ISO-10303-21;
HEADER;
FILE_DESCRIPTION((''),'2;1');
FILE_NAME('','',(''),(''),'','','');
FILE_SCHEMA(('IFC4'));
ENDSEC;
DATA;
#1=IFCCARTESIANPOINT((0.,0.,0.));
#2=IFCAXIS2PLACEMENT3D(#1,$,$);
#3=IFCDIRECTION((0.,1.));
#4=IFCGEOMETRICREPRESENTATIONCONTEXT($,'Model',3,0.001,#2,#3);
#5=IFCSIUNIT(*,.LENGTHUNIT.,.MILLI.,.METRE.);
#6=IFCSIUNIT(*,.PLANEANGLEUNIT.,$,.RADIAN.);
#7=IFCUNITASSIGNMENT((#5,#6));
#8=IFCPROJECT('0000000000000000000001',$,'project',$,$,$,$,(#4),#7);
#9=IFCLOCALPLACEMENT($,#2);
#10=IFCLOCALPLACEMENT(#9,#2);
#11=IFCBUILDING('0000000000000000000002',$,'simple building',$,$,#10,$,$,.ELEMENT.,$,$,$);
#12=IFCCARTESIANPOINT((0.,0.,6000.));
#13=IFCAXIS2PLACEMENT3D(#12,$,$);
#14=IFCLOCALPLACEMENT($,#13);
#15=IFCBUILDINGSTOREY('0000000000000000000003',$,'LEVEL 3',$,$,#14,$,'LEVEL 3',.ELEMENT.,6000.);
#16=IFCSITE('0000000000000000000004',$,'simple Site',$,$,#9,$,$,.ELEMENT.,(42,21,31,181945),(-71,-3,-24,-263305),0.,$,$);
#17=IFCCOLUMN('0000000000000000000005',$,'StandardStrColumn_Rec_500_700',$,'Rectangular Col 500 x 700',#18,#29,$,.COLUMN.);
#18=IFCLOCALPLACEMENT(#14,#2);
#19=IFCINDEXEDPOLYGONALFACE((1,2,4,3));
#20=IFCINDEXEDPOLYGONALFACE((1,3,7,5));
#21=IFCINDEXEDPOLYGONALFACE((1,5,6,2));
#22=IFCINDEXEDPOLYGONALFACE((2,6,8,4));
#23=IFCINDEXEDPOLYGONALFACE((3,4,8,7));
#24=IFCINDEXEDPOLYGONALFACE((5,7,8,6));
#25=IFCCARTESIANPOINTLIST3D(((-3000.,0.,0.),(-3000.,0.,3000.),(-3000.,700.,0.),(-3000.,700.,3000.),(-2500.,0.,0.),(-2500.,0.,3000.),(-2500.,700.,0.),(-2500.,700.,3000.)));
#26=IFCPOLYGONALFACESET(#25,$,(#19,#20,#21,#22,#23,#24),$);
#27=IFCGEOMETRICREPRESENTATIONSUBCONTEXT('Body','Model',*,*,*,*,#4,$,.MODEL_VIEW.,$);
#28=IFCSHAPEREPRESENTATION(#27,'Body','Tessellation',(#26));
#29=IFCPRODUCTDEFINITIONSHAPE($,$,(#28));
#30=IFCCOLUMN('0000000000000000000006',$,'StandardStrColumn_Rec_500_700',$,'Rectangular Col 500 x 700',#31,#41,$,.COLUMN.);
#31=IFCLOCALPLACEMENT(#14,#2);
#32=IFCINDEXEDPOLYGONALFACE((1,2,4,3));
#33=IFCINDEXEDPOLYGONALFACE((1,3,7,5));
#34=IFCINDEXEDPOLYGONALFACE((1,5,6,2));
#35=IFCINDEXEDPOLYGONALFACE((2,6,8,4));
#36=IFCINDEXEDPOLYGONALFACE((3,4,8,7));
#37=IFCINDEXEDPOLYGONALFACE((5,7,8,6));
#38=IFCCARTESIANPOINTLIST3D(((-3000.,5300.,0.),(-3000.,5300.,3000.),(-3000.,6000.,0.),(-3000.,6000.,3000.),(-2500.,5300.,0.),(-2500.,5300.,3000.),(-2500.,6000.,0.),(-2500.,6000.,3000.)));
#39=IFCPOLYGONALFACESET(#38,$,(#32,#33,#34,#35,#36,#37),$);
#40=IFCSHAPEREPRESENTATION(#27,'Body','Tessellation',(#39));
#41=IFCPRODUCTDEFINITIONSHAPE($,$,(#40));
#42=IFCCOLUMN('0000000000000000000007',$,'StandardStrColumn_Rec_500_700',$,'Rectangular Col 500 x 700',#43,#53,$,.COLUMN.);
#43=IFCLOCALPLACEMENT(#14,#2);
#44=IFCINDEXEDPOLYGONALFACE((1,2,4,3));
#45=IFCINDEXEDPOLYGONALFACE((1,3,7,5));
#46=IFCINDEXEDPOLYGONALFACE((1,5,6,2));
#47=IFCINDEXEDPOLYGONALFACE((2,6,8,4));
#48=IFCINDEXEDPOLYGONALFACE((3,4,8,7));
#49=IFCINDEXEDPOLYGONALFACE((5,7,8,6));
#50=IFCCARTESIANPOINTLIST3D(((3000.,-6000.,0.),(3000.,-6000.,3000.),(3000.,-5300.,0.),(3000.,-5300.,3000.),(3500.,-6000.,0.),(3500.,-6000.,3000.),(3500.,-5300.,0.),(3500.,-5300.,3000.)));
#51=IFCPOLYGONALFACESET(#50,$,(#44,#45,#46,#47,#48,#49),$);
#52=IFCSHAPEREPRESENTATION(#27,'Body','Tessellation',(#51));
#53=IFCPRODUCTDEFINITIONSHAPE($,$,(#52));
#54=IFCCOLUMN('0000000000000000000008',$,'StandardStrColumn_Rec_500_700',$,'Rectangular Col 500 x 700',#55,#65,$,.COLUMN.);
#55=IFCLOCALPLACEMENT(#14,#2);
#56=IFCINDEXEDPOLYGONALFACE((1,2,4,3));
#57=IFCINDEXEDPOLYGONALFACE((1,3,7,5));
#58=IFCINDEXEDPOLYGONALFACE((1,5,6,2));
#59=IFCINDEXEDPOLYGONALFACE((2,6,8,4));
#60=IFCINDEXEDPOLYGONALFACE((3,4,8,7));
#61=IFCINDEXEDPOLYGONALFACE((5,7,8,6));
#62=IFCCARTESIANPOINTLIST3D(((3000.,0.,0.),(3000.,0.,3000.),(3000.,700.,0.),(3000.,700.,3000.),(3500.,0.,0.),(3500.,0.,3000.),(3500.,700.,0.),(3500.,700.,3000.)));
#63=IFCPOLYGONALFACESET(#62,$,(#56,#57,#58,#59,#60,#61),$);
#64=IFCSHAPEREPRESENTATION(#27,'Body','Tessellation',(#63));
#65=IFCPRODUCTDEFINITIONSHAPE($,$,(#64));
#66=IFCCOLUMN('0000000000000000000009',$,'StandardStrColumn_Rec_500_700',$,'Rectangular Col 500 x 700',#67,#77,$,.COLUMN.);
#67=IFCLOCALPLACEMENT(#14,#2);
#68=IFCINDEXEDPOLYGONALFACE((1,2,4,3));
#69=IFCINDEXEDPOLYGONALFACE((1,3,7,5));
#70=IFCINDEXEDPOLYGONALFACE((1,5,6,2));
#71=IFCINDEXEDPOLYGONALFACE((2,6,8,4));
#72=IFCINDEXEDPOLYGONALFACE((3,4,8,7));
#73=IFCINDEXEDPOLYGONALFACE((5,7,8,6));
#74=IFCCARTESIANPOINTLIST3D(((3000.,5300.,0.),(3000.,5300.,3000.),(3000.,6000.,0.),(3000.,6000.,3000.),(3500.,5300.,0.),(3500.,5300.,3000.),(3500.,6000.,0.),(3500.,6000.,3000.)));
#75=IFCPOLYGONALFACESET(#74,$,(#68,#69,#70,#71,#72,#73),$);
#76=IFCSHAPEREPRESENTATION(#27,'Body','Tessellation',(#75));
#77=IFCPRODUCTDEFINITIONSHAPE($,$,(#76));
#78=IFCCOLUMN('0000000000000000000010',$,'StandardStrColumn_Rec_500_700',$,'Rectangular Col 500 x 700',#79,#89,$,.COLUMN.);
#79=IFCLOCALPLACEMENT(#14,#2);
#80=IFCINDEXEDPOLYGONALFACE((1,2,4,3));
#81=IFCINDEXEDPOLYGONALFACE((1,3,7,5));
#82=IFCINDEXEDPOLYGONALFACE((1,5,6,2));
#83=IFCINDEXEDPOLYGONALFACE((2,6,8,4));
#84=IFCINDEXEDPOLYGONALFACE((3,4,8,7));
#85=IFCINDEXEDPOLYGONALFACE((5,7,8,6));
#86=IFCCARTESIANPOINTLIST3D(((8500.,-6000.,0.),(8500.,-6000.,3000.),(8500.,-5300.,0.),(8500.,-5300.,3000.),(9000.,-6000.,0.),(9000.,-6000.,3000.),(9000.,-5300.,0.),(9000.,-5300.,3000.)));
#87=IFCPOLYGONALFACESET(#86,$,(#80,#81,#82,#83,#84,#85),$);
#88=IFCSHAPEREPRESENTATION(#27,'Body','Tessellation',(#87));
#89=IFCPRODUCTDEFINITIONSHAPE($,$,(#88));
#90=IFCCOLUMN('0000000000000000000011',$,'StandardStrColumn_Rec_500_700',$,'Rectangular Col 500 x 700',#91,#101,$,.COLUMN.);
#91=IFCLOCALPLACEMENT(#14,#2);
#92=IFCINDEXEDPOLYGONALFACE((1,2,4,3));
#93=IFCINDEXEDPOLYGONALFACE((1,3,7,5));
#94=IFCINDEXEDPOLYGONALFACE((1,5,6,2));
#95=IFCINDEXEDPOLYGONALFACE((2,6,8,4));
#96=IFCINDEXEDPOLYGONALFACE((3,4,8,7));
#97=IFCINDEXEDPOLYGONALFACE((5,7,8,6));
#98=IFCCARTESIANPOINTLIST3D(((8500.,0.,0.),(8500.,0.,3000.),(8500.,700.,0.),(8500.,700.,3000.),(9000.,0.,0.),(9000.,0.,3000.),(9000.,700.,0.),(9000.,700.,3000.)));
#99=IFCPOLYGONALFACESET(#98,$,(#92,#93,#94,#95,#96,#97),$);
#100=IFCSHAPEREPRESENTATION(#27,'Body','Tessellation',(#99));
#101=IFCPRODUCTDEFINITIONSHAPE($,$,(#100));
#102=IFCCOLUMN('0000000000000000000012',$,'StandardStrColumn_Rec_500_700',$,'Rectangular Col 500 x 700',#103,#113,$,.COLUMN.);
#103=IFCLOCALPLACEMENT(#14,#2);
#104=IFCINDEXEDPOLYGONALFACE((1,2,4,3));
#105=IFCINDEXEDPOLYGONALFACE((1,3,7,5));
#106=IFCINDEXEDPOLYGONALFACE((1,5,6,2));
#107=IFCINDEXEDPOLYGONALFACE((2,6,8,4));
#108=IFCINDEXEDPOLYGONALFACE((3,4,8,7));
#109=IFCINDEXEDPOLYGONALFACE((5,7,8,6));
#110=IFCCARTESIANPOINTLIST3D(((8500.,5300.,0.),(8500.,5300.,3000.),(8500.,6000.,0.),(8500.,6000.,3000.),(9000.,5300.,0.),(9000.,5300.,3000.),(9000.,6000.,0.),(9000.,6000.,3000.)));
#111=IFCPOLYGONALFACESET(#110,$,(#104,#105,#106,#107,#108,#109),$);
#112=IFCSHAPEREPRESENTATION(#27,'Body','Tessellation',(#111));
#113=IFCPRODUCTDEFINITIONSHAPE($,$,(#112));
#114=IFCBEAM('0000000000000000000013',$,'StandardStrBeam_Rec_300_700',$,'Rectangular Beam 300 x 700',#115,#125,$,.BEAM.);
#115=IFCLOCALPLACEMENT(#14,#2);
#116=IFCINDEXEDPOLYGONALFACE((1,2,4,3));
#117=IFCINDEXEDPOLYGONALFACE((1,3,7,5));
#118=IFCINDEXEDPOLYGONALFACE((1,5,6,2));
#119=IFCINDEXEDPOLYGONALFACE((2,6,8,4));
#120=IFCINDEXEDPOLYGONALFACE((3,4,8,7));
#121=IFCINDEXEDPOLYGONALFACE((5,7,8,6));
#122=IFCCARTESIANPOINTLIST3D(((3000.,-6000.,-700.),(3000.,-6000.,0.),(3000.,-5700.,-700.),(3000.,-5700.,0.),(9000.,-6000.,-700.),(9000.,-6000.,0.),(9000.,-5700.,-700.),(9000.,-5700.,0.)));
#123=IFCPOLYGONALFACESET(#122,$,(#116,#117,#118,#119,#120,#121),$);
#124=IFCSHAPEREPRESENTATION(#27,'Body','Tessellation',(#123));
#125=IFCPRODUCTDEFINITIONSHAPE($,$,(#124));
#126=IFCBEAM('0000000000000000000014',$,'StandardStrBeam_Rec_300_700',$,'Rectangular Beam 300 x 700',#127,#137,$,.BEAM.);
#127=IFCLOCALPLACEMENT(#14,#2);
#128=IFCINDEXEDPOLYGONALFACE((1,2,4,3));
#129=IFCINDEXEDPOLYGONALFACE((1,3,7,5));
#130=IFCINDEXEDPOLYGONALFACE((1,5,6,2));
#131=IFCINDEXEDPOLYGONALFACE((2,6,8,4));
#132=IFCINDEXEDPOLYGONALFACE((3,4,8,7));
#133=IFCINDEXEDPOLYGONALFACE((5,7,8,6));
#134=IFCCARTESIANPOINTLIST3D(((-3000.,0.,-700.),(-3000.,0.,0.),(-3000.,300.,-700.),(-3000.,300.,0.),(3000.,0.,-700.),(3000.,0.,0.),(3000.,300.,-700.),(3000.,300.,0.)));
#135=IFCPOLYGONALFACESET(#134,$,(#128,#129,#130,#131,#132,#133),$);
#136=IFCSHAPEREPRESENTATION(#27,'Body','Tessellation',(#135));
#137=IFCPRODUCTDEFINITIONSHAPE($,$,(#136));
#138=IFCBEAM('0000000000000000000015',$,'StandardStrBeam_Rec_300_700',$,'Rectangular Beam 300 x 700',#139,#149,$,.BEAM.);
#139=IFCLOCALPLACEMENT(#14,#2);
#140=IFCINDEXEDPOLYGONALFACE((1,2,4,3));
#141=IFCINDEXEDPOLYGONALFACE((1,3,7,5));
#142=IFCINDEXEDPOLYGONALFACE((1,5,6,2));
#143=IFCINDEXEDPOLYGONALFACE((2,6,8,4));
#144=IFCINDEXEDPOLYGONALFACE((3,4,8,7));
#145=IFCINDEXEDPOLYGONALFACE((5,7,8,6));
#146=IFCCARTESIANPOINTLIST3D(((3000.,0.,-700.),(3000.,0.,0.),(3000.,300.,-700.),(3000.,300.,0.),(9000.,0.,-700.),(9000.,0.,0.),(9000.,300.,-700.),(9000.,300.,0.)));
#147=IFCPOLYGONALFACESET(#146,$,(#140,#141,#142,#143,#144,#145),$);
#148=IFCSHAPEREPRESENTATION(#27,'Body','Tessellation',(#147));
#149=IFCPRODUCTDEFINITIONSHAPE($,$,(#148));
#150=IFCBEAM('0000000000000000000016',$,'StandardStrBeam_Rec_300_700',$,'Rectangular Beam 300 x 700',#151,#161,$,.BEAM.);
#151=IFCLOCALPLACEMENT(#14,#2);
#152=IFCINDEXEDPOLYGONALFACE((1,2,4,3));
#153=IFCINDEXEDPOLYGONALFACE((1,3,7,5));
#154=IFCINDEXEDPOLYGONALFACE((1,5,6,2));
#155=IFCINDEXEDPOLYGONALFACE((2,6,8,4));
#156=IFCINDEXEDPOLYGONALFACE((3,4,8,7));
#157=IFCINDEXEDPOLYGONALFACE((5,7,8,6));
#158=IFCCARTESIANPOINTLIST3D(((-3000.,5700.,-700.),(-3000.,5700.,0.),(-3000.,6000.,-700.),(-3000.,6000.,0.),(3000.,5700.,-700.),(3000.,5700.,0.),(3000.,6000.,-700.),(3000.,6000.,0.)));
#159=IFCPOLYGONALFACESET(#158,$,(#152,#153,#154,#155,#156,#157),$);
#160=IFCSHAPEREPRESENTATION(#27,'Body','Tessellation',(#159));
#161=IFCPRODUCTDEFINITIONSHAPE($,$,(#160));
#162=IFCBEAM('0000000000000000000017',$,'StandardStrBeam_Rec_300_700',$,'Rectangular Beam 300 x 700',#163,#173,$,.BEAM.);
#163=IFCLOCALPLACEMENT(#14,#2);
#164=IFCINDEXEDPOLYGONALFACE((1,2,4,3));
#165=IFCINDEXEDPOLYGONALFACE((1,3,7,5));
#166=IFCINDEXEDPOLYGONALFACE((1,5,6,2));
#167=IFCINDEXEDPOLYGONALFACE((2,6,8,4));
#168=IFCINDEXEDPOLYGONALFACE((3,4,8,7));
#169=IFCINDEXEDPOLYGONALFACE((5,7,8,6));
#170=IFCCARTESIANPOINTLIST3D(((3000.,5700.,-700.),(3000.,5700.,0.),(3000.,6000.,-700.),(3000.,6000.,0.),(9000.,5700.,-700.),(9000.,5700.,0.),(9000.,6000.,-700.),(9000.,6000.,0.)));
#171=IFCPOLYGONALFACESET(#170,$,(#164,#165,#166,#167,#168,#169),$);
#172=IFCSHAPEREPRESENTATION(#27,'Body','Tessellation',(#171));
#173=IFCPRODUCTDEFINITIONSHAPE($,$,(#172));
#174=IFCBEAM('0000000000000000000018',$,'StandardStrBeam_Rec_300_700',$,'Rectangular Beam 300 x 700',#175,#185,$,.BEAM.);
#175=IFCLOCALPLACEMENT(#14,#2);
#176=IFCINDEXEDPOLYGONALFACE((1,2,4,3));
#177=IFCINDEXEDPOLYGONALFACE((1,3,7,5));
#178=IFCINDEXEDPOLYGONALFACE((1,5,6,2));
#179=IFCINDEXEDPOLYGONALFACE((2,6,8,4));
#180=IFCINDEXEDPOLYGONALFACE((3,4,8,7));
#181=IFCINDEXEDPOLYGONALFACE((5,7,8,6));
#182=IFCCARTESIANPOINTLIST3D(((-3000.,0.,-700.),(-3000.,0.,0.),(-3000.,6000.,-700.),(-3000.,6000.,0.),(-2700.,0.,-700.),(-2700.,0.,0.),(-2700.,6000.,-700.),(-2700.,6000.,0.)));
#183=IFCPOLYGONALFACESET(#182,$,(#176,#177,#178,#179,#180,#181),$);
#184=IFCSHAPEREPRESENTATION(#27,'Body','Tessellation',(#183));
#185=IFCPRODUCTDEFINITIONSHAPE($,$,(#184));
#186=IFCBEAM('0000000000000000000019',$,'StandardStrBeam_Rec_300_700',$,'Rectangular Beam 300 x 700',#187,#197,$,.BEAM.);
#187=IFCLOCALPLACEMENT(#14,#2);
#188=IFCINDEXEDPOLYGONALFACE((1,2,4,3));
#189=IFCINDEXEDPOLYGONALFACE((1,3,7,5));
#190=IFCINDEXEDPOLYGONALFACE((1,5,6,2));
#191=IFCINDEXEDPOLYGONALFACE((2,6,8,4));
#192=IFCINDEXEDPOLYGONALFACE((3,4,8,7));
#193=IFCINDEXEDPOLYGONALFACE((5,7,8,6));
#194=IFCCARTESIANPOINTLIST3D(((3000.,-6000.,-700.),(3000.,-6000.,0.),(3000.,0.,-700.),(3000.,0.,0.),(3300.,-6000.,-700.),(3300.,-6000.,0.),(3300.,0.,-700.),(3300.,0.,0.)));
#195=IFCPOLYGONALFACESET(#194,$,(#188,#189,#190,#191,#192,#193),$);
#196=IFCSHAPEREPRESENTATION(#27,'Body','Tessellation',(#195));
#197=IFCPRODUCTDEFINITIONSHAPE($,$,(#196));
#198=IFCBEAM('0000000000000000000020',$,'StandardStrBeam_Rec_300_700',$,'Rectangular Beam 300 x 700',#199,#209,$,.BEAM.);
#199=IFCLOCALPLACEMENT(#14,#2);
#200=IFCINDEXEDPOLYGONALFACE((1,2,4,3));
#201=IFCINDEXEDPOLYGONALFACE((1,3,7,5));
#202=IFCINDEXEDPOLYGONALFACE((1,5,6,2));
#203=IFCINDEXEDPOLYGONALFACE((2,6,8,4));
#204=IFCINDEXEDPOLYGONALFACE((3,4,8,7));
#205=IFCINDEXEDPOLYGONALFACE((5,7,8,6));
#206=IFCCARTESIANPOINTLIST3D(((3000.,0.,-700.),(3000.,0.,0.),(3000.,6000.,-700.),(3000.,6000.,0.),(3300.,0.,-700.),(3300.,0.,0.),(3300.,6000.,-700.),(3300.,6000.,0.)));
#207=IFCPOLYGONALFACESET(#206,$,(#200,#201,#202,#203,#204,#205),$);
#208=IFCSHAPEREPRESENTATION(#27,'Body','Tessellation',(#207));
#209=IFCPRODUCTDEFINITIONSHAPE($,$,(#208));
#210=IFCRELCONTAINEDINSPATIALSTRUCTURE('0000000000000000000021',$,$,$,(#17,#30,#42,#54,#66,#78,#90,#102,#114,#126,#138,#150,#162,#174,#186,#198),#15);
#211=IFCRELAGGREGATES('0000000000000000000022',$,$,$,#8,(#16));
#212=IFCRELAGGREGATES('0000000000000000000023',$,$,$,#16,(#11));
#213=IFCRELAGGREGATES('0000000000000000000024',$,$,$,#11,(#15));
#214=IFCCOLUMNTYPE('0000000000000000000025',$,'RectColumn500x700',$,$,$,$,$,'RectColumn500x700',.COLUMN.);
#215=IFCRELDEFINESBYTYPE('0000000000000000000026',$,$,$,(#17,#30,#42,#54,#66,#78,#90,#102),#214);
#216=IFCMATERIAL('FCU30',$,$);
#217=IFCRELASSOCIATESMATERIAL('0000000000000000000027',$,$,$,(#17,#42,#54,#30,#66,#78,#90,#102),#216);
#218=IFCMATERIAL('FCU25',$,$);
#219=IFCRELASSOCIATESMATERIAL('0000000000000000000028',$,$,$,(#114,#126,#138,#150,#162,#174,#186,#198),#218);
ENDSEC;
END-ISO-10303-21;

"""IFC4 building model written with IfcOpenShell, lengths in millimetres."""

from ifc_helpers import new_model, si_unit, direction, frame, origin, origin_with_axes, origin_2d_with_axis, place, context, subcontext, project, spatial, rectangle, extrude, material, material_profile, profile_set, profile_usage, type_object, element, save


model = new_model("IFC4")

# Units and contexts
model_context = context("Model", 3, precision=0.001, world=origin(), true_north=direction((0.0, 1.0)))
body_context = subcontext(model_context, "Body", "Model", "MODEL_VIEW")
ifc_project = project(units=[si_unit("LENGTHUNIT", "METRE", prefix="MILLI"), si_unit("PLANEANGLEUNIT", "RADIAN")], contexts=[model_context])

# Site, building, storey
site_placement = place(None, origin())
site = spatial("IfcSite", under=ifc_project, at=site_placement, Name="simple Site", CompositionType="ELEMENT", RefLatitude=(42, 21, 31, 181945), RefLongitude=(-71, -3, -24, -263305), RefElevation=0.0)
building_placement = place(site_placement, origin())
building = spatial("IfcBuilding", under=site, at=building_placement, Name="simple building", CompositionType="ELEMENT")
storey_placement = place(None, frame((0.0, 0.0, 6000.0)))
storey = spatial("IfcBuildingStorey", under=building, at=storey_placement, Name="LEVEL 3", LongName="LEVEL 3", CompositionType="ELEMENT", Elevation=6000.0)

# Columns
ifc_material_1 = material(Name="FCU30")
ifc_material_profile_1 = material_profile(ifc_material_1, rectangle(XDim=500.0, YDim=700.0, at=origin_2d_with_axis()))
ifc_profile_set_1 = profile_set([ifc_material_profile_1])
ifc_profile_usage_1 = profile_usage(ifc_profile_set_1, cardinal=7)
column_type = type_object("IfcColumnType", Name="RectColumn500x700", ElementType="RectColumn500x700", PredefinedType="COLUMN")
column_1_placement = place(None, frame((-2750.0, 350.0, 6000.0), z_axis=(0.0, 0.0, 1.0), x_axis=(1.0, 0.0, 0.0)))
element("IfcColumn", 1, at=column_1_placement, inside=storey, type_object=column_type, material=ifc_profile_usage_1, Name="StandardStrColumn_Rec_500_700", ObjectType="Rectangular Col 500 x 700", PredefinedType="COLUMN", context=body_context, shape_type="SweptSolid", body=[
    extrude(rectangle(XDim=500.0, YDim=700.0, at=origin_2d_with_axis()), origin_with_axes(), (0.0, 0.0, 1.0), 3000.0),
])
ifc_profile_usage_2 = profile_usage(ifc_profile_set_1, cardinal=1)
column_2_placement = place(None, frame((-2750.0, 5650.0, 6000.0), z_axis=(0.0, 0.0, 1.0), x_axis=(1.0, 0.0, 0.0)))
element("IfcColumn", 2, at=column_2_placement, inside=storey, type_object=column_type, material=ifc_profile_usage_2, Name="StandardStrColumn_Rec_500_700", ObjectType="Rectangular Col 500 x 700", PredefinedType="COLUMN", context=body_context, shape_type="SweptSolid", body=[
    extrude(rectangle(XDim=500.0, YDim=700.0, at=origin_2d_with_axis()), origin_with_axes(), (0.0, 0.0, 1.0), 3000.0),
])
for number, where, z_axis, x_axis, name in (
    (3, (3250.0, -5650.0, 6000.0), (0.0, 0.0, 1.0), (1.0, 0.0, 0.0), "StandardStrColumn_Rec_500_700"),
    (4, (3250.0, 350.0, 6000.0), (0.0, 0.0, 1.0), (1.0, 0.0, 0.0), "StandardStrColumn_Rec_500_700"),
):
    element("IfcColumn", number, at=place(None, frame(where, z_axis=z_axis, x_axis=x_axis)), inside=storey, type_object=column_type, material=ifc_profile_usage_1, Name=name, ObjectType="Rectangular Col 500 x 700", PredefinedType="COLUMN", context=body_context, shape_type="SweptSolid", body=[
        extrude(rectangle(XDim=500.0, YDim=700.0, at=origin_2d_with_axis()), origin_with_axes(), (0.0, 0.0, 1.0), 3000.0),
    ])
column_3_placement = place(None, frame((3250.0, 5650.0, 6000.0), z_axis=(0.0, 0.0, 1.0), x_axis=(1.0, 0.0, 0.0)))
element("IfcColumn", 5, at=column_3_placement, inside=storey, type_object=column_type, material=ifc_profile_usage_2, Name="StandardStrColumn_Rec_500_700", ObjectType="Rectangular Col 500 x 700", PredefinedType="COLUMN", context=body_context, shape_type="SweptSolid", body=[
    extrude(rectangle(XDim=500.0, YDim=700.0, at=origin_2d_with_axis()), origin_with_axes(), (0.0, 0.0, 1.0), 3000.0),
])
ifc_profile_usage_3 = profile_usage(ifc_profile_set_1, cardinal=9)
for number, where, z_axis, x_axis, name in (
    (6, (8750.0, -5650.0, 6000.0), (0.0, 0.0, 1.0), (1.0, 0.0, 0.0), "StandardStrColumn_Rec_500_700"),
    (7, (8750.0, 350.0, 6000.0), (0.0, 0.0, 1.0), (1.0, 0.0, 0.0), "StandardStrColumn_Rec_500_700"),
):
    element("IfcColumn", number, at=place(None, frame(where, z_axis=z_axis, x_axis=x_axis)), inside=storey, type_object=column_type, material=ifc_profile_usage_3, Name=name, ObjectType="Rectangular Col 500 x 700", PredefinedType="COLUMN", context=body_context, shape_type="SweptSolid", body=[
        extrude(rectangle(XDim=500.0, YDim=700.0, at=origin_2d_with_axis()), origin_with_axes(), (0.0, 0.0, 1.0), 3000.0),
    ])
ifc_profile_usage_4 = profile_usage(ifc_profile_set_1, cardinal=3)
column_4_placement = place(None, frame((8750.0, 5650.0, 6000.0), z_axis=(0.0, 0.0, 1.0), x_axis=(1.0, 0.0, 0.0)))
element("IfcColumn", 8, at=column_4_placement, inside=storey, type_object=column_type, material=ifc_profile_usage_4, Name="StandardStrColumn_Rec_500_700", ObjectType="Rectangular Col 500 x 700", PredefinedType="COLUMN", context=body_context, shape_type="SweptSolid", body=[
    extrude(rectangle(XDim=500.0, YDim=700.0, at=origin_2d_with_axis()), origin_with_axes(), (0.0, 0.0, 1.0), 3000.0),
])

# Beams
ifc_material_2 = material(Name="FCU25")
ifc_material_profile_2 = material_profile(ifc_material_2, rectangle(XDim=300.0, YDim=700.0, at=origin_2d_with_axis()))
ifc_profile_set_2 = profile_set([ifc_material_profile_2])
ifc_profile_usage_5 = profile_usage(ifc_profile_set_2, cardinal=9)
for number, where, z_axis, x_axis, name in (
    (9, (3000.0, -5850.0, 5650.0), (1.0, 0.0, 0.0), (0.0, -1.0, 0.0), "StandardStrBeam_Rec_300_700"),
    (10, (-3000.0, 150.0, 5650.0), (1.0, 0.0, 0.0), (0.0, -1.0, 0.0), "StandardStrBeam_Rec_300_700"),
    (11, (3000.0, 150.0, 5650.0), (1.0, 0.0, 0.0), (0.0, -1.0, 0.0), "StandardStrBeam_Rec_300_700"),
):
    element("IfcBeam", number, at=place(None, frame(where, z_axis=z_axis, x_axis=x_axis)), inside=storey, material=ifc_profile_usage_5, Name=name, ObjectType="Rectangular Beam 300 x 700", PredefinedType="BEAM", context=body_context, shape_type="SweptSolid", body=[
        extrude(rectangle(XDim=300.0, YDim=700.0, at=origin_2d_with_axis()), origin_with_axes(), (0.0, 0.0, 1.0), 6000.0),
    ])
ifc_profile_usage_6 = profile_usage(ifc_profile_set_2, cardinal=7)
for number, where, z_axis, x_axis, name in (
    (12, (-3000.0, 5850.0, 5650.0), (1.0, 0.0, 0.0), (0.0, -1.0, 0.0), "StandardStrBeam_Rec_300_700"),
    (13, (3000.0, 5850.0, 5650.0), (1.0, 0.0, 0.0), (0.0, -1.0, 0.0), "StandardStrBeam_Rec_300_700"),
    (14, (-2850.0, 0.0, 5650.0), (0.0, 1.0, 0.0), (1.0, 0.0, 0.0), "StandardStrBeam_Rec_300_700"),
    (15, (3150.0, -6000.0, 5650.0), (0.0, 1.0, 0.0), (1.0, 0.0, 0.0), "StandardStrBeam_Rec_300_700"),
    (16, (3150.0, 0.0, 5650.0), (0.0, 1.0, 0.0), (1.0, 0.0, 0.0), "StandardStrBeam_Rec_300_700"),
):
    element("IfcBeam", number, at=place(None, frame(where, z_axis=z_axis, x_axis=x_axis)), inside=storey, material=ifc_profile_usage_6, Name=name, ObjectType="Rectangular Beam 300 x 700", PredefinedType="BEAM", context=body_context, shape_type="SweptSolid", body=[
        extrude(rectangle(XDim=300.0, YDim=700.0, at=origin_2d_with_axis()), origin_with_axes(), (0.0, 0.0, 1.0), 6000.0),
    ])

save(model, "model.ifc")
